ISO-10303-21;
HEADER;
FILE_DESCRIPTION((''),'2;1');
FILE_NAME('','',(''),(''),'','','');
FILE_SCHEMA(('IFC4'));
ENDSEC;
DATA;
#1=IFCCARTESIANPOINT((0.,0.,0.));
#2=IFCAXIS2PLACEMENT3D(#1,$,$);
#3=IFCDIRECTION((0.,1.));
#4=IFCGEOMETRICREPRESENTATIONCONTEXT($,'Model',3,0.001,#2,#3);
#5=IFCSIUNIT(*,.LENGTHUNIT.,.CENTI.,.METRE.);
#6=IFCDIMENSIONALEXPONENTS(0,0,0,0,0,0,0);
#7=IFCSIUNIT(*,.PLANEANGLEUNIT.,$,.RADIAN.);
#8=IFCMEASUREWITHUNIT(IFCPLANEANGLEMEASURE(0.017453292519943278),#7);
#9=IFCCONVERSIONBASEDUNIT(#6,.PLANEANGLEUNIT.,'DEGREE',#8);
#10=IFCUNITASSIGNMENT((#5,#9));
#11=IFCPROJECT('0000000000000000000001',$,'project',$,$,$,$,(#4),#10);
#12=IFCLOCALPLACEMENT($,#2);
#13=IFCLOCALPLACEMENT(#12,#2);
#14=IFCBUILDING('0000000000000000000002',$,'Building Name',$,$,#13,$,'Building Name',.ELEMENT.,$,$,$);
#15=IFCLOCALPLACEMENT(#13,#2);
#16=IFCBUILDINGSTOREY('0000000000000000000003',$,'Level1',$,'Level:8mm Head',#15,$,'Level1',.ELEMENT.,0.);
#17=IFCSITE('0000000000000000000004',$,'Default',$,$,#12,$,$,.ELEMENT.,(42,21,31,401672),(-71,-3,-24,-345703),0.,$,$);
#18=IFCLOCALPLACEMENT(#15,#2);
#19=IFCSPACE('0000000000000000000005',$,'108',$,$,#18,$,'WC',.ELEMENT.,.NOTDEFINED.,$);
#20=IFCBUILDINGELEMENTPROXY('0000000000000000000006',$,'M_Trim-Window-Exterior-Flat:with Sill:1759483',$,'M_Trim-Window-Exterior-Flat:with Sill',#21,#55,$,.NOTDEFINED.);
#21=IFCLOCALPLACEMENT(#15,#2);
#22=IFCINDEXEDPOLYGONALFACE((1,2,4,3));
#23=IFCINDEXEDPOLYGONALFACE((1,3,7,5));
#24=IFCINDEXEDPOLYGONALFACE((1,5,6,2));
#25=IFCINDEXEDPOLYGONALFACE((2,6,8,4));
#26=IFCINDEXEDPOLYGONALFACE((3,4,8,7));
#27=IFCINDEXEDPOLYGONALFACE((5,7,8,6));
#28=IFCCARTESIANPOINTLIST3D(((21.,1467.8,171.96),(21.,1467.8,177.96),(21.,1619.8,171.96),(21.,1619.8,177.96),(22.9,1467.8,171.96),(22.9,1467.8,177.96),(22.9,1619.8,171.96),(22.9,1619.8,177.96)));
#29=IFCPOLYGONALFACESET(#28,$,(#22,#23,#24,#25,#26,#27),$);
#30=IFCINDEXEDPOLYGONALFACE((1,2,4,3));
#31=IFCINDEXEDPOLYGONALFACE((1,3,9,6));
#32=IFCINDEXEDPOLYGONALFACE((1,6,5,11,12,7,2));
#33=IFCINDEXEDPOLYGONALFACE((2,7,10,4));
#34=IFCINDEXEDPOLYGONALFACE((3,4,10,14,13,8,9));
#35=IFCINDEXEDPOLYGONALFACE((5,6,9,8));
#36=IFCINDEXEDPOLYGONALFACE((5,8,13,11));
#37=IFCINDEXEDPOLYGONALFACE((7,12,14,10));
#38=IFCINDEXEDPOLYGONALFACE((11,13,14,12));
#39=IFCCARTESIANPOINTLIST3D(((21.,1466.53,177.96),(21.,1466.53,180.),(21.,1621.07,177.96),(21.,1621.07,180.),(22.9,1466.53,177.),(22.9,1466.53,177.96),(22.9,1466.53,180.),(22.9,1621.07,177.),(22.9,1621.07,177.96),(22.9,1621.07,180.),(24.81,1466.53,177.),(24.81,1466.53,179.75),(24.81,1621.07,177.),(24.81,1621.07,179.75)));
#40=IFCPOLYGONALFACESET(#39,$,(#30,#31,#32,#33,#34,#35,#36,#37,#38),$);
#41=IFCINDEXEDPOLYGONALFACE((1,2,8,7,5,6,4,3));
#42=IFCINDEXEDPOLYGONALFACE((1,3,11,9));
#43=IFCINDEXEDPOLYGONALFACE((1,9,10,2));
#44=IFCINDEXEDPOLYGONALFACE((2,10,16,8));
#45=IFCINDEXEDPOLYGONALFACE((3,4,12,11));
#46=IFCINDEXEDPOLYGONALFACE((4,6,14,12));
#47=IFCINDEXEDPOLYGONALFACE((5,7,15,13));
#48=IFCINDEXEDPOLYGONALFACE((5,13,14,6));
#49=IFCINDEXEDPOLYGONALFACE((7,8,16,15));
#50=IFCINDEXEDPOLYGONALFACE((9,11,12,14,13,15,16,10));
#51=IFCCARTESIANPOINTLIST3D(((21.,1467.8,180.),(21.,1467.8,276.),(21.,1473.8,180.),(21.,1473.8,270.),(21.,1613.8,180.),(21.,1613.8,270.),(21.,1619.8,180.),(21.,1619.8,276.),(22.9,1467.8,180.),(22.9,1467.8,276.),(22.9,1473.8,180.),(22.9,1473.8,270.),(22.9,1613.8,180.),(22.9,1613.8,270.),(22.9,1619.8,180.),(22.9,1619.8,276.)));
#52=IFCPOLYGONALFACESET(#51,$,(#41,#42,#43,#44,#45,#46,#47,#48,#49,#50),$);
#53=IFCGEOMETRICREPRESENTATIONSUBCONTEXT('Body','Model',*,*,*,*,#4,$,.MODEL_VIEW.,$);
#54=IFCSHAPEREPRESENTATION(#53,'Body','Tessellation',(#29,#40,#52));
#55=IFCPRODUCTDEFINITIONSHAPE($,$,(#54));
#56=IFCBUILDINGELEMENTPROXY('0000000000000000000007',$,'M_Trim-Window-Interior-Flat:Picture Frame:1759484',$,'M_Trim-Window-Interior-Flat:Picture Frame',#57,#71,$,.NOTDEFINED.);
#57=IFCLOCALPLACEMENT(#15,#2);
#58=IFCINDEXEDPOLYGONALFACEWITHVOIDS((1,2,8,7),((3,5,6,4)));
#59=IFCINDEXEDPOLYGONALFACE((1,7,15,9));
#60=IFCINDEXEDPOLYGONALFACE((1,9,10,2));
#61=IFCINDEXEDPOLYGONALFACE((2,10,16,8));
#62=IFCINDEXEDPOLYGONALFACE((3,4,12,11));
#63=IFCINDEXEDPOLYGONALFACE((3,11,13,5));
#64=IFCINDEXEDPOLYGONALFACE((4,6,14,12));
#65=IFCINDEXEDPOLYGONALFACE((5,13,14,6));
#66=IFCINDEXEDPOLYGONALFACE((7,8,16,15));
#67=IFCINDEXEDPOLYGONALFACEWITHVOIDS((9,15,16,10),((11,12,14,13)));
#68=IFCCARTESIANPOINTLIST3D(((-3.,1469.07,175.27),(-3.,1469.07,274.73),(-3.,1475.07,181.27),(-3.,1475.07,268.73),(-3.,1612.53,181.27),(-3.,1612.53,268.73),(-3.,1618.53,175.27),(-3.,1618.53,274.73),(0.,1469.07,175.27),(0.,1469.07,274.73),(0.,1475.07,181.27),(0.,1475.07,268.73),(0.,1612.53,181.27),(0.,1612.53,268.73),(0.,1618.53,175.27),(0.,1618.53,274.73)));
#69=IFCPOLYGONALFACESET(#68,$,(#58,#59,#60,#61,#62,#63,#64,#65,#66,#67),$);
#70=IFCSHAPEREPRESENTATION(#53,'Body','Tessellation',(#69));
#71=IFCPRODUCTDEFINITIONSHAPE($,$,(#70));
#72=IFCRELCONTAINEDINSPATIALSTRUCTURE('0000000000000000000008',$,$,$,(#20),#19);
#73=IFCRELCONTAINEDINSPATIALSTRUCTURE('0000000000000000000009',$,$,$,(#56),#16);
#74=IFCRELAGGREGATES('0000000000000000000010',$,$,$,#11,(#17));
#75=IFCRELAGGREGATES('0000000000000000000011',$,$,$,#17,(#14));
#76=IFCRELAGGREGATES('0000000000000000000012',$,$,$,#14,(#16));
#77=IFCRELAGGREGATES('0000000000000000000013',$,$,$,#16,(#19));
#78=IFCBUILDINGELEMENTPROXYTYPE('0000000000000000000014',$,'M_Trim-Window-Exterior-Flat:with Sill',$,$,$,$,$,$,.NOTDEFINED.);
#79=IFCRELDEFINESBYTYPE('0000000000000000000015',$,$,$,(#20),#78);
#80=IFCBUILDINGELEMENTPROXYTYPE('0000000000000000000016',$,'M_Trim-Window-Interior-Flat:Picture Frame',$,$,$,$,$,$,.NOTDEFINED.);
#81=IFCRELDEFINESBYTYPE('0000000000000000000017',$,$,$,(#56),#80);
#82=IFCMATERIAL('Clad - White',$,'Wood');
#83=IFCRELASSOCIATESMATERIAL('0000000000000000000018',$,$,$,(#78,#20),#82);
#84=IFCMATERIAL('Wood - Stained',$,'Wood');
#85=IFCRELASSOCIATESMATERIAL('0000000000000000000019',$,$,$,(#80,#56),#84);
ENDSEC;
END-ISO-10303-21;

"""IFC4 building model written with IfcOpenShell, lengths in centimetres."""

from ifc_helpers import new_model, entity, si_unit, converted_unit, direction, frame, origin, place, context, subcontext, project, spatial, indexed_curve, outline, extrude, source, transform, mapped, material, type_object, type_shapes, element, save


model = new_model("IFC4")

# Units and contexts
model_context = context("Model", 3, precision=0.001, world=origin(), true_north=direction((0.0, 1.0)))
body_context = subcontext(model_context, "Body", "Model", "MODEL_VIEW")
ifc_project = project(units=[si_unit("LENGTHUNIT", "METRE", prefix="CENTI"), converted_unit("PLANEANGLEUNIT", "DEGREE", entity("IfcPlaneAngleMeasure", 0.017453292519943278), si_unit("PLANEANGLEUNIT", "RADIAN"), dimensions=[0, 0, 0, 0, 0, 0, 0])], contexts=[model_context])

# Site, building, storey
site_placement = place(None, origin())
site = spatial("IfcSite", under=ifc_project, at=site_placement, Name="Default", CompositionType="ELEMENT", RefLatitude=(42, 21, 31, 401672), RefLongitude=(-71, -3, -24, -345703), RefElevation=0.0)
building_placement = place(site_placement, origin())
building = spatial("IfcBuilding", under=site, at=building_placement, Name="Building Name", LongName="Building Name", CompositionType="ELEMENT")
storey_placement = place(building_placement, origin())
storey = spatial("IfcBuildingStorey", under=building, at=storey_placement, Name="Level1", ObjectType="Level:8mm Head", LongName="Level1", CompositionType="ELEMENT", Elevation=0.0)

# Shared definitions
ifc_material_1 = material(Name="Clad - White", Category="Wood")
ifc_material_2 = material(Name="Wood - Stained", Category="Wood")

# Shared definitions
space_1_placement = place(storey_placement, origin())
space_1 = spatial("IfcSpace", under=storey, at=space_1_placement, Name="108", LongName="WC", CompositionType="ELEMENT", PredefinedType="NOTDEFINED")

# Building element proxies
building_element_proxy_type_1 = type_object("IfcBuildingElementProxyType", Name="M_Trim-Window-Exterior-Flat:with Sill", PredefinedType="NOTDEFINED", material=ifc_material_1)
shared_shape_1 = source(origin(), body_context, "Body", "SweptSolid", [
    extrude(outline(indexed_curve([(-3.0, -76.0), (3.0, -76.0), (3.0, 76.0), (-3.0, 76.0), (-3.0, -76.0)], self_intersect=False)), frame((0.0, 95.04, 0.0), z_axis=(0.0, 0.0, 1.0), x_axis=(0.0, 1.0, 0.0)), (0.0, 0.0, 1.0), 1.9),
    extrude(outline(indexed_curve([(-1.52, -1.9), (1.23, -1.9), (1.48, 0.0), (1.48, 1.9), (-0.57, 1.9), (-0.57, 0.0), (-1.52, 0.0), (-1.52, -1.9)], self_intersect=False)), frame((-77.27, 91.48, 1.9), z_axis=(1.0, 0.0, 0.0), x_axis=(0.0, -1.0, 0.0)), (0.0, 0.0, 1.0), 154.54),
    extrude(outline(indexed_curve([(-76.0, -49.5), (76.0, -49.5), (76.0, 46.5), (70.0, 46.5), (70.0, -43.5), (-70.0, -43.5), (-70.0, 46.5), (-76.0, 46.5), (-76.0, -49.5)], self_intersect=False)), frame((0.0, 43.5, 0.0)), (0.0, 0.0, 1.0), 1.9),
])
type_shapes(building_element_proxy_type_1, [shared_shape_1])
proxy_1_placement = place(space_1_placement, frame((21.0, 1543.8, 270.0), z_axis=(1.0, 0.0, 0.0), x_axis=(0.0, -1.0, 0.0)))
element("IfcBuildingElementProxy", 1, at=proxy_1_placement, inside=space_1, type_object=building_element_proxy_type_1, material=ifc_material_1, Name="M_Trim-Window-Exterior-Flat:with Sill:1759483", ObjectType="M_Trim-Window-Exterior-Flat:with Sill", PredefinedType="NOTDEFINED", context=body_context, shape_type="MappedRepresentation", body=[
    mapped(shared_shape_1, transform((0.0, 0.0, 0.0), scale=1.0)),
])
building_element_proxy_type_2 = type_object("IfcBuildingElementProxyType", Name="M_Trim-Window-Interior-Flat:Picture Frame", PredefinedType="NOTDEFINED", material=ifc_material_2)
shared_shape_2 = source(origin(), body_context, "Body", "SweptSolid", [
    extrude(outline(indexed_curve([(-49.73, -74.73), (49.73, -74.73), (49.73, 74.73), (-49.73, 74.73), (-49.73, -74.73)], self_intersect=False), holes=[indexed_curve([(-43.73, -68.73), (-43.73, 68.73), (43.73, 68.73), (43.73, -68.73), (-43.73, -68.73)], self_intersect=False)]), frame((0.0, 45.0, 0.0), z_axis=(0.0, 0.0, 1.0), x_axis=(0.0, 1.0, 0.0)), (0.0, 0.0, 1.0), 3.0),
])
type_shapes(building_element_proxy_type_2, [shared_shape_2])
proxy_2_placement = place(storey_placement, frame((0.0, 1543.8, 270.0), z_axis=(-1.0, 0.0, 0.0), x_axis=(0.0, 1.0, 0.0)))
element("IfcBuildingElementProxy", 2, at=proxy_2_placement, inside=storey, type_object=building_element_proxy_type_2, material=ifc_material_2, Name="M_Trim-Window-Interior-Flat:Picture Frame:1759484", ObjectType="M_Trim-Window-Interior-Flat:Picture Frame", PredefinedType="NOTDEFINED", context=body_context, shape_type="MappedRepresentation", body=[
    mapped(shared_shape_2, transform((0.0, 0.0, 0.0), scale=1.0)),
])

save(model, "model.ifc")
